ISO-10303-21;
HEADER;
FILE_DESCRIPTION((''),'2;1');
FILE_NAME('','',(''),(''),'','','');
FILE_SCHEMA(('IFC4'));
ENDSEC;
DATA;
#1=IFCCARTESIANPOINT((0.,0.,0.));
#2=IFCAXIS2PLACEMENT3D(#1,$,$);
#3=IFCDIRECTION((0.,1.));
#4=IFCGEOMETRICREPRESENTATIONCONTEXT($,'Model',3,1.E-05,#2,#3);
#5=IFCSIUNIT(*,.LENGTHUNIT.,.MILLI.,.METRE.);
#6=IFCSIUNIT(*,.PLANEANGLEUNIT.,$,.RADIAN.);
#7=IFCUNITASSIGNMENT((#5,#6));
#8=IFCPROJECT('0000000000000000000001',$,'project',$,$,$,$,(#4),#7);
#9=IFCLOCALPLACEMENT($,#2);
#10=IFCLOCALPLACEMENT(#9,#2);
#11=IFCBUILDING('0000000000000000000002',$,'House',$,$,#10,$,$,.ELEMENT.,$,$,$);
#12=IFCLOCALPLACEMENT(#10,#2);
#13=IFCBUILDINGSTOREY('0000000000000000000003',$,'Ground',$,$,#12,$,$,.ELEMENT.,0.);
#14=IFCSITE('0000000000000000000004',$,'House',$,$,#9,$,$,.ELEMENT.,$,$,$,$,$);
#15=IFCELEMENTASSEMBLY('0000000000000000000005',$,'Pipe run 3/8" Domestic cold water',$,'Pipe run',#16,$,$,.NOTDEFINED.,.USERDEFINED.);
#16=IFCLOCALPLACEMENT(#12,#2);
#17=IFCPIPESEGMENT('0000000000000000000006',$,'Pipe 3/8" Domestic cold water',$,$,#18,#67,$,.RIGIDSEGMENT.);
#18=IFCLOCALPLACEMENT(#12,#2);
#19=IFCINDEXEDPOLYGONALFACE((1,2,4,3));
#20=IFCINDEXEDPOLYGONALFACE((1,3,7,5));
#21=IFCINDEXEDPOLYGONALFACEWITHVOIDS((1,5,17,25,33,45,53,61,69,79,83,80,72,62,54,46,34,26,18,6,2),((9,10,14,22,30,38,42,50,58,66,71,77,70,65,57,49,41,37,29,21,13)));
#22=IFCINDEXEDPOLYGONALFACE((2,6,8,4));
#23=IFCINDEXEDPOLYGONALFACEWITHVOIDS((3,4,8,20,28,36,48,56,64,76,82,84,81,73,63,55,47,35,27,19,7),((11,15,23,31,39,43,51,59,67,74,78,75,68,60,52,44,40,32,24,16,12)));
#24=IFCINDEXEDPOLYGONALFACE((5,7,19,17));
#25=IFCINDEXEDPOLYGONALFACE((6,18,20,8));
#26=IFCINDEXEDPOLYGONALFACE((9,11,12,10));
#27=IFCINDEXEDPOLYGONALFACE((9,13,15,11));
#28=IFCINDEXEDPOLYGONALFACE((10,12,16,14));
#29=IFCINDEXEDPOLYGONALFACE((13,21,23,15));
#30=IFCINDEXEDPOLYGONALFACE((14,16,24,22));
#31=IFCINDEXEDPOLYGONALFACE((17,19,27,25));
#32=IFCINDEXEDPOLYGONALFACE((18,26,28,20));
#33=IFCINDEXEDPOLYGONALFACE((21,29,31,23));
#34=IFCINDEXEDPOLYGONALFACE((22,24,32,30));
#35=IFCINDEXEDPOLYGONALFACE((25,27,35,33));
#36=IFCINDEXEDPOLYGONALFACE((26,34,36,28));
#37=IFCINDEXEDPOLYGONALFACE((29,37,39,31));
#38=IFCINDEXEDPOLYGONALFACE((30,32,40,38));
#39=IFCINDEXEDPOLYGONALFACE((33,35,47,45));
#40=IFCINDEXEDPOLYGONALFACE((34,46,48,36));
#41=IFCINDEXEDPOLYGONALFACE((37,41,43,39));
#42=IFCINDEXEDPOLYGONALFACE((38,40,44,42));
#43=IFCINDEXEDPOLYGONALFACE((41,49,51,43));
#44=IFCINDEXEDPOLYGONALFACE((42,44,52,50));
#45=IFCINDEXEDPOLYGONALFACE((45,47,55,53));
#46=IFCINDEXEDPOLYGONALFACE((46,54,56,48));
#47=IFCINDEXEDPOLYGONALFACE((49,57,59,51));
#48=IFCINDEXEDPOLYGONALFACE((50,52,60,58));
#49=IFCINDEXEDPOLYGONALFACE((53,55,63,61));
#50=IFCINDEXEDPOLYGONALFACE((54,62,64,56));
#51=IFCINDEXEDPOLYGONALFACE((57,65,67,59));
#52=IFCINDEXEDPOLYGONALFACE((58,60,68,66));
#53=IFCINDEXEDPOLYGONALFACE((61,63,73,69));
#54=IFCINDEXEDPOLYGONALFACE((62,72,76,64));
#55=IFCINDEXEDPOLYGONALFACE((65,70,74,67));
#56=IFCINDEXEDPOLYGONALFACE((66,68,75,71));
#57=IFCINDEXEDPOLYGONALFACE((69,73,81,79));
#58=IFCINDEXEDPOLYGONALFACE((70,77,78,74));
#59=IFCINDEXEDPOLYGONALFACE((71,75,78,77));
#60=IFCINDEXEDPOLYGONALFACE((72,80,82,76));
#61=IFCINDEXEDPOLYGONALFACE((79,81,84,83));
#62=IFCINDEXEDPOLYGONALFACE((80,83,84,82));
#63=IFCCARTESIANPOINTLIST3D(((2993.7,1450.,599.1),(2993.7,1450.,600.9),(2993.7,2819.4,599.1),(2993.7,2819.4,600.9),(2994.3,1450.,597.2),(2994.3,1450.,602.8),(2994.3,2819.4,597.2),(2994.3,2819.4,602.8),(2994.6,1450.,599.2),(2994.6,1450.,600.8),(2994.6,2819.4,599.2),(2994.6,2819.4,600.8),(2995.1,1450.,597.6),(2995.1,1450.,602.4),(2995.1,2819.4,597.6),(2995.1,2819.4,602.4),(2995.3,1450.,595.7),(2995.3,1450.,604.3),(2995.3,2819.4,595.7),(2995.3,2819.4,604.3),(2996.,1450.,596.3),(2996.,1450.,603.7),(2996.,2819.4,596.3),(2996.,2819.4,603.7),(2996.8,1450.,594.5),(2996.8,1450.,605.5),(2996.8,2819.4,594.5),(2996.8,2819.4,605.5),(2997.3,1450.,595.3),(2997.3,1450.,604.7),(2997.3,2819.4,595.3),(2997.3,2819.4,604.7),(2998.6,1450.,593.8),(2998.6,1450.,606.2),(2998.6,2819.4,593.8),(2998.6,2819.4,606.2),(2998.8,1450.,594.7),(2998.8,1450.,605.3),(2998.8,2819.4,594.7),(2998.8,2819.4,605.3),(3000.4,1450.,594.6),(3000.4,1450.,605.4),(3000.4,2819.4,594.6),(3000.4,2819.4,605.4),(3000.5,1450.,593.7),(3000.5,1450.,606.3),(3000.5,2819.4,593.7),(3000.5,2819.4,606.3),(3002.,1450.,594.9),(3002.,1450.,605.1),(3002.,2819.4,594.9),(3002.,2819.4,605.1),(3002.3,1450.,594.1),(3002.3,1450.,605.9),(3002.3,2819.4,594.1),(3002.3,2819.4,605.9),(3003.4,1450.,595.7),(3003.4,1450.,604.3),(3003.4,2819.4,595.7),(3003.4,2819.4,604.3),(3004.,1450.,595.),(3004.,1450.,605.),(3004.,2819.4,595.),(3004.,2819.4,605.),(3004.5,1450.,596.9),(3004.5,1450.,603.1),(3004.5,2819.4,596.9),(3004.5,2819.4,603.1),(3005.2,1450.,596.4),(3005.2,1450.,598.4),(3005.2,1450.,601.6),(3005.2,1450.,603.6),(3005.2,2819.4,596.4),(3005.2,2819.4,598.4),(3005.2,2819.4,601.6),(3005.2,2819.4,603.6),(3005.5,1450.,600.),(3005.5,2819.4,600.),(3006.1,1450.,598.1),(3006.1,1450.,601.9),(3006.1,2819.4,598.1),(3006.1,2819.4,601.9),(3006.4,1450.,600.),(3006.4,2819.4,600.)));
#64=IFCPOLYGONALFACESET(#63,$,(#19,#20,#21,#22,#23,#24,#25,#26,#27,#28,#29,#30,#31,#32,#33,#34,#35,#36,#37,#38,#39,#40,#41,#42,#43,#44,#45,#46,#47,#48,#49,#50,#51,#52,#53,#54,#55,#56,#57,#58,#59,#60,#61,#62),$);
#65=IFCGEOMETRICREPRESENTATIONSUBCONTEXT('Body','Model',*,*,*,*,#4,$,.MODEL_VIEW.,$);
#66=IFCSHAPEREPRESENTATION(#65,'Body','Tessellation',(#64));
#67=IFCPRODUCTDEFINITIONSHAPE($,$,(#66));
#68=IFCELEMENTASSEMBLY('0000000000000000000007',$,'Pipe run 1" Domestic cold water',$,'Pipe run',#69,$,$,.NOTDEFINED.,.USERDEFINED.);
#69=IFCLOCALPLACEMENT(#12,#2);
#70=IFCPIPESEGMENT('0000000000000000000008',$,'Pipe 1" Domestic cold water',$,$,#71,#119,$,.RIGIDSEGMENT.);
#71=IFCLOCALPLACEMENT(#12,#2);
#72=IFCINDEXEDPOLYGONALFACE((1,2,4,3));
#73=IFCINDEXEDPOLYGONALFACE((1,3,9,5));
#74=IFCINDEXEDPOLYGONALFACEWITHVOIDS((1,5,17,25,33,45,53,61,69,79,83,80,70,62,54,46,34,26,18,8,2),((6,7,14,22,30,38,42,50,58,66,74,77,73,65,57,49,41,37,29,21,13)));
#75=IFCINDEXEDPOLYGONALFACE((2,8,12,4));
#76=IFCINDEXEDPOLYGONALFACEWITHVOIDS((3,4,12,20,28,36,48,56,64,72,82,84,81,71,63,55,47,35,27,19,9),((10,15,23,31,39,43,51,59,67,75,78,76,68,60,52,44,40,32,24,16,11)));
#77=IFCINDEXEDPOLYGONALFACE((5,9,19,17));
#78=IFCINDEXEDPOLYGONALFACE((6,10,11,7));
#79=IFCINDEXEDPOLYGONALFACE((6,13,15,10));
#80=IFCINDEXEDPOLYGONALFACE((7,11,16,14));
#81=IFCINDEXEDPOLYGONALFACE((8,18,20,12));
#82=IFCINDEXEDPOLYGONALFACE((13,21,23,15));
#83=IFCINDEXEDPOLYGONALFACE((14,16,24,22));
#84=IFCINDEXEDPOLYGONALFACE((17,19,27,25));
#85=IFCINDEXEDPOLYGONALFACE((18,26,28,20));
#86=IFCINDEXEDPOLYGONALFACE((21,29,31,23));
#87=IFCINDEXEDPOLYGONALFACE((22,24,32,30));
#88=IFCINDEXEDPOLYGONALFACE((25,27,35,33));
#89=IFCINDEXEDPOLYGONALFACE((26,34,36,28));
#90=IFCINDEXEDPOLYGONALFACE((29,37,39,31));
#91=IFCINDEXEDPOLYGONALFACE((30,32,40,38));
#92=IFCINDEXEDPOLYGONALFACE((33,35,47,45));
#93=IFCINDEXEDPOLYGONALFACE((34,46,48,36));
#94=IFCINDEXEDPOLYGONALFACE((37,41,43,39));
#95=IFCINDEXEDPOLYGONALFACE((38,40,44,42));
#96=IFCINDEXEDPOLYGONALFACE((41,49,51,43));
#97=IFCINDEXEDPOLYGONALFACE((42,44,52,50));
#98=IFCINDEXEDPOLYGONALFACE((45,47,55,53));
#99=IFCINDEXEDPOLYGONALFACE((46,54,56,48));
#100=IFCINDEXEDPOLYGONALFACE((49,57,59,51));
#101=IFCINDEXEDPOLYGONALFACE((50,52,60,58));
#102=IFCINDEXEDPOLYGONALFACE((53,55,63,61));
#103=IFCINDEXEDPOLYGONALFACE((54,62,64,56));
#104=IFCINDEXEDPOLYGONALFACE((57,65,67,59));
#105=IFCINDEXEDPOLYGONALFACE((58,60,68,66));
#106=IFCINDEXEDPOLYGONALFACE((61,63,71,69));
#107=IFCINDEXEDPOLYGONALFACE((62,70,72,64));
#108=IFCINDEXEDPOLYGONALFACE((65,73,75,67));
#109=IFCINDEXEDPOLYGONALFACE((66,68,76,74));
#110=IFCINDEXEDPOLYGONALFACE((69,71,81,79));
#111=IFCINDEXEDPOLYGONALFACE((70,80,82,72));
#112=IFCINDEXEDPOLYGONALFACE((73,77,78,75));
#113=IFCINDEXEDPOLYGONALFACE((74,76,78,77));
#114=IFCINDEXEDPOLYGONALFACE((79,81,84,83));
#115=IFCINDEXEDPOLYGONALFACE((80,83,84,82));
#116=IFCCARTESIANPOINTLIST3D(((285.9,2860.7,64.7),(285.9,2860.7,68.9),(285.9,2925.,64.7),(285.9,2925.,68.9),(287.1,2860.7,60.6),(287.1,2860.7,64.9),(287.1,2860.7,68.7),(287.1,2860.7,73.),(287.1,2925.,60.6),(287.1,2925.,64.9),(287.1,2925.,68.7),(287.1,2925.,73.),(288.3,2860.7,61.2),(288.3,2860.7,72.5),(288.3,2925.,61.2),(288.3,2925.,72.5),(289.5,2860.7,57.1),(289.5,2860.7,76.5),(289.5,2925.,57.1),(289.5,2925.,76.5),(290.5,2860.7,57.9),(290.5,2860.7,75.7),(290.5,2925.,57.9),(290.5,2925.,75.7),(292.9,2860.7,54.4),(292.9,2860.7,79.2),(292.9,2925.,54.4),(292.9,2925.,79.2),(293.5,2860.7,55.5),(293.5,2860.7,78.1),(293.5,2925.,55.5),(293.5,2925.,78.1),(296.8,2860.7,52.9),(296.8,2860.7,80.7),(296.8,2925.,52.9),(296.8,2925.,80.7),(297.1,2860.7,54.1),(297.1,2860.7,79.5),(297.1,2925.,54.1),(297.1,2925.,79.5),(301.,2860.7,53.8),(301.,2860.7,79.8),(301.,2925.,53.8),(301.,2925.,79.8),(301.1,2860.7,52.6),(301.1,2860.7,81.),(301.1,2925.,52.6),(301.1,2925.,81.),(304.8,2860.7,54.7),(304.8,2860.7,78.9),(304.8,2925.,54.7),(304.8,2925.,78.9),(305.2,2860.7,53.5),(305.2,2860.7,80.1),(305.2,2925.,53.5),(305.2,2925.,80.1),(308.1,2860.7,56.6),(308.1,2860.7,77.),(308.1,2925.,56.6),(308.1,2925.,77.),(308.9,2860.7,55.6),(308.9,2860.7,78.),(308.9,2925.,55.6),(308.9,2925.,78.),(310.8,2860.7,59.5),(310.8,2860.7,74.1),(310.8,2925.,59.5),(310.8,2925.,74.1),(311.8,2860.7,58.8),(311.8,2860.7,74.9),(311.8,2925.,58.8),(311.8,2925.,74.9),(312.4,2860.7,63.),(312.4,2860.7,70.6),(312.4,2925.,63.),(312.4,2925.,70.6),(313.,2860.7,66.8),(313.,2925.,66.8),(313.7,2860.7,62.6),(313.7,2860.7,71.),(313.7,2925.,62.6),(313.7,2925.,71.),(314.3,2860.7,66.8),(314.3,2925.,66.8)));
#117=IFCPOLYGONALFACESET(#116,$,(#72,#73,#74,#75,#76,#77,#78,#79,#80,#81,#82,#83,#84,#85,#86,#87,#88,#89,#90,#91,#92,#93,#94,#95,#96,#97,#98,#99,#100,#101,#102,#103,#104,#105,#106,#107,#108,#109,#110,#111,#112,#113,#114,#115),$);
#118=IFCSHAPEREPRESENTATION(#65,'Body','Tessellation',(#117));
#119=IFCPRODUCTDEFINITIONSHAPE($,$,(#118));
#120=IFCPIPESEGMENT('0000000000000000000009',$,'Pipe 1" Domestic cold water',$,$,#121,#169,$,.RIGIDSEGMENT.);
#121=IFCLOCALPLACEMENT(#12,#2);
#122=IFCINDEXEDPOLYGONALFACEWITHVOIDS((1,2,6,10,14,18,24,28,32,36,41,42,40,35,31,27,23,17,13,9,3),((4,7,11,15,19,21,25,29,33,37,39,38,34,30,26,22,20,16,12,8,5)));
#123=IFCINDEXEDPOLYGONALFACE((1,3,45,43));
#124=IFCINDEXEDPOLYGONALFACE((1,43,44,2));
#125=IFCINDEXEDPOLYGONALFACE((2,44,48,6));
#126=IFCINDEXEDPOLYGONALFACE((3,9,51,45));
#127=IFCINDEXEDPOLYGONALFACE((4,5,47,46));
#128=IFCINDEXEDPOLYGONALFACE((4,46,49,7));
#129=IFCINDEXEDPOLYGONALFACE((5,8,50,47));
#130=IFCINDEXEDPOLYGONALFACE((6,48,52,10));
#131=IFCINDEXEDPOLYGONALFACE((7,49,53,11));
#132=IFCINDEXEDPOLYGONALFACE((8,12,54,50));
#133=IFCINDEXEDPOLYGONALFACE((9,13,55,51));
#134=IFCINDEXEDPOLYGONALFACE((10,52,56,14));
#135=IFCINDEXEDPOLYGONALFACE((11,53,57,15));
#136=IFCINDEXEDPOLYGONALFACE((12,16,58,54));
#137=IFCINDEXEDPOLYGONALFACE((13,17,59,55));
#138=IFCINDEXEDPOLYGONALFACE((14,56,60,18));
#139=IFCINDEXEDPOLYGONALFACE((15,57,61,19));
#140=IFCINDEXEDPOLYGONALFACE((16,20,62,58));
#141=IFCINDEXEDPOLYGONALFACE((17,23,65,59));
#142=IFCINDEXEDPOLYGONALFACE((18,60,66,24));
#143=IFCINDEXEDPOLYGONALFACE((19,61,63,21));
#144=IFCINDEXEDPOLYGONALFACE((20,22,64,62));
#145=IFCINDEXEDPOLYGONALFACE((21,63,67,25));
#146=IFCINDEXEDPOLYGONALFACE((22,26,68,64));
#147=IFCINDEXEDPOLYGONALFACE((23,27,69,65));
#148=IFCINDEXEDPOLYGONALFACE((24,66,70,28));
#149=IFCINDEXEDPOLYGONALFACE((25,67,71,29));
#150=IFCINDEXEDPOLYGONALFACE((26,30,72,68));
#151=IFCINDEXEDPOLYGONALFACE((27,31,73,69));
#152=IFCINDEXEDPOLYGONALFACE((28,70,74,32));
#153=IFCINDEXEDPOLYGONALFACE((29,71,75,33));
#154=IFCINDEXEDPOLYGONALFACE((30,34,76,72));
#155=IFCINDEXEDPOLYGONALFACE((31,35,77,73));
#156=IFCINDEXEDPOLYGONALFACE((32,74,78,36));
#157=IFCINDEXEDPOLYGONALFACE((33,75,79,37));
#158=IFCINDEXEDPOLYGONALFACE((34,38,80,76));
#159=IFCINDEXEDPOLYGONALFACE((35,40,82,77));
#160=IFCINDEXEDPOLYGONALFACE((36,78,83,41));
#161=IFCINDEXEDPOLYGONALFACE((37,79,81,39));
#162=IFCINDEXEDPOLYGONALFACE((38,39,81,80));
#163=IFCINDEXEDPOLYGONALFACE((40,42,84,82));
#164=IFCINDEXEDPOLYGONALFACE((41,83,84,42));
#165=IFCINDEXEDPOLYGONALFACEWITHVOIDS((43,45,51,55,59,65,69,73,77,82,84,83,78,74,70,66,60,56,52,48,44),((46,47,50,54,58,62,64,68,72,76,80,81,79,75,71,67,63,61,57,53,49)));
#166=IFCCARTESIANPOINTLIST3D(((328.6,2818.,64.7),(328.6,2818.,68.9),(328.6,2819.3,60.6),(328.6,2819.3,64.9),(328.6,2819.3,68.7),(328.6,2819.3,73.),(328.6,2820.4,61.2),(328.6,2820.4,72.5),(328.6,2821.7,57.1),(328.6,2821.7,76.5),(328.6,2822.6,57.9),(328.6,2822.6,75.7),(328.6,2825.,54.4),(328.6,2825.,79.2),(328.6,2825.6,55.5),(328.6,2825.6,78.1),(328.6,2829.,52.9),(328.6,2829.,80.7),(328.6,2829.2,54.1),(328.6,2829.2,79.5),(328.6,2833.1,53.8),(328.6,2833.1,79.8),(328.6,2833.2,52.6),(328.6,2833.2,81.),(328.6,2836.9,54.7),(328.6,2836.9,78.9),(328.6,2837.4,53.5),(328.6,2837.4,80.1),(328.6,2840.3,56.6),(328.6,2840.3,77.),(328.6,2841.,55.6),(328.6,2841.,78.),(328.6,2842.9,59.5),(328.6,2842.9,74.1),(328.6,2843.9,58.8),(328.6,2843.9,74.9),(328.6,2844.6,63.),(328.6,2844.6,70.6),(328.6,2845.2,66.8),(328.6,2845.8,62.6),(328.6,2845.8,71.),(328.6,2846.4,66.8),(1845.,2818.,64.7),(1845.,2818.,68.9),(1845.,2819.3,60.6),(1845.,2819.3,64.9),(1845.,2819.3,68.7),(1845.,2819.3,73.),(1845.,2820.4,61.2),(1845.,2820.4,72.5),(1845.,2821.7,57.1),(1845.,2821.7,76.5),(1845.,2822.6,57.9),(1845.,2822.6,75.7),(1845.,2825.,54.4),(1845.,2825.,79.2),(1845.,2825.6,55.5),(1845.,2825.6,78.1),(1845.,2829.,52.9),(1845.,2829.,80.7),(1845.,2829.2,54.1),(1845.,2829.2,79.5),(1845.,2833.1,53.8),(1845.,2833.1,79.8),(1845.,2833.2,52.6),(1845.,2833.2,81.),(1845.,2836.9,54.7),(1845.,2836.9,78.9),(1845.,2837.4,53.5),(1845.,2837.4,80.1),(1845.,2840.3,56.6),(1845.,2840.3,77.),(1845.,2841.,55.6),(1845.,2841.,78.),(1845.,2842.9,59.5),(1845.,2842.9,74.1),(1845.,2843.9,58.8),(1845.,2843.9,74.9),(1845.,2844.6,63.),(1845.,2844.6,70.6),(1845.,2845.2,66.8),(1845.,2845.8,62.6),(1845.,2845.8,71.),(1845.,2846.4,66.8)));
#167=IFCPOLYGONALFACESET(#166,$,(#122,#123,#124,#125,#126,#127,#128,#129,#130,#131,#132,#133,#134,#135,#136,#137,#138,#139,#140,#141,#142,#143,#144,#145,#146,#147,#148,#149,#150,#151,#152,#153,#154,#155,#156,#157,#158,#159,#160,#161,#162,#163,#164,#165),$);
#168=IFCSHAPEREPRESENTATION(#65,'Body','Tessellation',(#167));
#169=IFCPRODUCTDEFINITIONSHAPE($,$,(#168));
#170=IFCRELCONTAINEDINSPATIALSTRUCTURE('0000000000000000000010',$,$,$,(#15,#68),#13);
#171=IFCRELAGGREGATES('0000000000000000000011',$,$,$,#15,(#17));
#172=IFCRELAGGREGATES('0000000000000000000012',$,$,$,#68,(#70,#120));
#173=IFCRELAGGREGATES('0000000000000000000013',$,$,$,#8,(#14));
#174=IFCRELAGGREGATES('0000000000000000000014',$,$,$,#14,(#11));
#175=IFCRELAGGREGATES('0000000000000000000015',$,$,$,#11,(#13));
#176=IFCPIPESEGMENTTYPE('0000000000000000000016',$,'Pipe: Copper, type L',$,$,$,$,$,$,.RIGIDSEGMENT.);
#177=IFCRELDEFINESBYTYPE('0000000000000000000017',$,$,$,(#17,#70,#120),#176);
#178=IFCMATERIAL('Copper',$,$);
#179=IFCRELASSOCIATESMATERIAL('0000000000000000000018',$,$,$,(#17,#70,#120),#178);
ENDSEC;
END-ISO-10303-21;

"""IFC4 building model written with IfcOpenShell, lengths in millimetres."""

from ifc_helpers import new_model, si_unit, direction, frame, origin, origin_with_axes, origin_2d, place, context, subcontext, project, spatial, hollow_circle, extrude, material, type_object, element, aggregate, save


model = new_model("IFC4")

# Units and contexts
model_context = context("Model", 3, precision=1e-05, world=origin(), true_north=direction((0.0, 1.0)))
body_context = subcontext(model_context, "Body", "Model", "MODEL_VIEW")
ifc_project = project(units=[si_unit("LENGTHUNIT", "METRE", prefix="MILLI"), si_unit("PLANEANGLEUNIT", "RADIAN")], contexts=[model_context])

# Site, building, storey
site_placement = place(None, origin())
site = spatial("IfcSite", under=ifc_project, at=site_placement, Name="House", CompositionType="ELEMENT")
building_placement = place(site_placement, origin())
building = spatial("IfcBuilding", under=site, at=building_placement, Name="House", CompositionType="ELEMENT")
storey_placement = place(building_placement, origin())
storey = spatial("IfcBuildingStorey", under=building, at=storey_placement, Name="Ground", CompositionType="ELEMENT", Elevation=0.0)

# Shared definitions
ifc_material = material(Name="Copper")
pipe_segment_type = type_object("IfcPipeSegmentType", Name="Pipe: Copper, type L", PredefinedType="RIGIDSEGMENT")

# Element assemblies, pipe segments
assembly_1_placement = place(storey_placement, origin_with_axes())
assembly_1 = element("IfcElementAssembly", 1, at=assembly_1_placement, inside=storey, Name="Pipe run 3/8\" Domestic cold water", ObjectType="Pipe run", AssemblyPlace="NOTDEFINED", PredefinedType="USERDEFINED")
pipe_segment_1_placement = place(storey_placement, origin_with_axes())
pipe_segment_1 = element("IfcPipeSegment", 2, at=pipe_segment_1_placement, type_object=pipe_segment_type, material=ifc_material, Name="Pipe 3/8\" Domestic cold water", PredefinedType="RIGIDSEGMENT", context=body_context, shape_type="SweptSolid", body=[
    extrude(hollow_circle(Radius=6.3, WallThickness=0.9, at=origin_2d()), frame((3000.0, 2819.4, 600.0), z_axis=(0.0, -1.0, 0.0), x_axis=(1.0, 0.0, 0.0)), (0.0, 0.0, 1.0), 1369.4),
])
assembly_2_placement = place(storey_placement, origin_with_axes())
assembly_2 = element("IfcElementAssembly", 3, at=assembly_2_placement, inside=storey, Name="Pipe run 1\" Domestic cold water", ObjectType="Pipe run", AssemblyPlace="NOTDEFINED", PredefinedType="USERDEFINED")
pipe_segment_2_placement = place(storey_placement, origin_with_axes())
pipe_segment_2 = element("IfcPipeSegment", 4, at=pipe_segment_2_placement, type_object=pipe_segment_type, material=ifc_material, Name="Pipe 1\" Domestic cold water", PredefinedType="RIGIDSEGMENT", context=body_context, shape_type="SweptSolid", body=[
    extrude(hollow_circle(Radius=14.3, WallThickness=1.3, at=origin_2d()), frame((300.0, 2925.0, 66.8), z_axis=(0.0, -1.0, 0.0), x_axis=(1.0, 0.0, 0.0)), (0.0, 0.0, 1.0), 64.3),
])
pipe_segment_3_placement = place(storey_placement, origin_with_axes())
pipe_segment_3 = element("IfcPipeSegment", 5, at=pipe_segment_3_placement, type_object=pipe_segment_type, material=ifc_material, Name="Pipe 1\" Domestic cold water", PredefinedType="RIGIDSEGMENT", context=body_context, shape_type="SweptSolid", body=[
    extrude(hollow_circle(Radius=14.3, WallThickness=1.3, at=origin_2d()), frame((328.6, 2832.1, 66.8), z_axis=(1.0, 0.0, 0.0), x_axis=(0.0, 1.0, 0.0)), (0.0, 0.0, 1.0), 1516.4),
])

aggregate(assembly_1, [pipe_segment_1])
aggregate(assembly_2, [pipe_segment_2, pipe_segment_3])

save(model, "model.ifc")
